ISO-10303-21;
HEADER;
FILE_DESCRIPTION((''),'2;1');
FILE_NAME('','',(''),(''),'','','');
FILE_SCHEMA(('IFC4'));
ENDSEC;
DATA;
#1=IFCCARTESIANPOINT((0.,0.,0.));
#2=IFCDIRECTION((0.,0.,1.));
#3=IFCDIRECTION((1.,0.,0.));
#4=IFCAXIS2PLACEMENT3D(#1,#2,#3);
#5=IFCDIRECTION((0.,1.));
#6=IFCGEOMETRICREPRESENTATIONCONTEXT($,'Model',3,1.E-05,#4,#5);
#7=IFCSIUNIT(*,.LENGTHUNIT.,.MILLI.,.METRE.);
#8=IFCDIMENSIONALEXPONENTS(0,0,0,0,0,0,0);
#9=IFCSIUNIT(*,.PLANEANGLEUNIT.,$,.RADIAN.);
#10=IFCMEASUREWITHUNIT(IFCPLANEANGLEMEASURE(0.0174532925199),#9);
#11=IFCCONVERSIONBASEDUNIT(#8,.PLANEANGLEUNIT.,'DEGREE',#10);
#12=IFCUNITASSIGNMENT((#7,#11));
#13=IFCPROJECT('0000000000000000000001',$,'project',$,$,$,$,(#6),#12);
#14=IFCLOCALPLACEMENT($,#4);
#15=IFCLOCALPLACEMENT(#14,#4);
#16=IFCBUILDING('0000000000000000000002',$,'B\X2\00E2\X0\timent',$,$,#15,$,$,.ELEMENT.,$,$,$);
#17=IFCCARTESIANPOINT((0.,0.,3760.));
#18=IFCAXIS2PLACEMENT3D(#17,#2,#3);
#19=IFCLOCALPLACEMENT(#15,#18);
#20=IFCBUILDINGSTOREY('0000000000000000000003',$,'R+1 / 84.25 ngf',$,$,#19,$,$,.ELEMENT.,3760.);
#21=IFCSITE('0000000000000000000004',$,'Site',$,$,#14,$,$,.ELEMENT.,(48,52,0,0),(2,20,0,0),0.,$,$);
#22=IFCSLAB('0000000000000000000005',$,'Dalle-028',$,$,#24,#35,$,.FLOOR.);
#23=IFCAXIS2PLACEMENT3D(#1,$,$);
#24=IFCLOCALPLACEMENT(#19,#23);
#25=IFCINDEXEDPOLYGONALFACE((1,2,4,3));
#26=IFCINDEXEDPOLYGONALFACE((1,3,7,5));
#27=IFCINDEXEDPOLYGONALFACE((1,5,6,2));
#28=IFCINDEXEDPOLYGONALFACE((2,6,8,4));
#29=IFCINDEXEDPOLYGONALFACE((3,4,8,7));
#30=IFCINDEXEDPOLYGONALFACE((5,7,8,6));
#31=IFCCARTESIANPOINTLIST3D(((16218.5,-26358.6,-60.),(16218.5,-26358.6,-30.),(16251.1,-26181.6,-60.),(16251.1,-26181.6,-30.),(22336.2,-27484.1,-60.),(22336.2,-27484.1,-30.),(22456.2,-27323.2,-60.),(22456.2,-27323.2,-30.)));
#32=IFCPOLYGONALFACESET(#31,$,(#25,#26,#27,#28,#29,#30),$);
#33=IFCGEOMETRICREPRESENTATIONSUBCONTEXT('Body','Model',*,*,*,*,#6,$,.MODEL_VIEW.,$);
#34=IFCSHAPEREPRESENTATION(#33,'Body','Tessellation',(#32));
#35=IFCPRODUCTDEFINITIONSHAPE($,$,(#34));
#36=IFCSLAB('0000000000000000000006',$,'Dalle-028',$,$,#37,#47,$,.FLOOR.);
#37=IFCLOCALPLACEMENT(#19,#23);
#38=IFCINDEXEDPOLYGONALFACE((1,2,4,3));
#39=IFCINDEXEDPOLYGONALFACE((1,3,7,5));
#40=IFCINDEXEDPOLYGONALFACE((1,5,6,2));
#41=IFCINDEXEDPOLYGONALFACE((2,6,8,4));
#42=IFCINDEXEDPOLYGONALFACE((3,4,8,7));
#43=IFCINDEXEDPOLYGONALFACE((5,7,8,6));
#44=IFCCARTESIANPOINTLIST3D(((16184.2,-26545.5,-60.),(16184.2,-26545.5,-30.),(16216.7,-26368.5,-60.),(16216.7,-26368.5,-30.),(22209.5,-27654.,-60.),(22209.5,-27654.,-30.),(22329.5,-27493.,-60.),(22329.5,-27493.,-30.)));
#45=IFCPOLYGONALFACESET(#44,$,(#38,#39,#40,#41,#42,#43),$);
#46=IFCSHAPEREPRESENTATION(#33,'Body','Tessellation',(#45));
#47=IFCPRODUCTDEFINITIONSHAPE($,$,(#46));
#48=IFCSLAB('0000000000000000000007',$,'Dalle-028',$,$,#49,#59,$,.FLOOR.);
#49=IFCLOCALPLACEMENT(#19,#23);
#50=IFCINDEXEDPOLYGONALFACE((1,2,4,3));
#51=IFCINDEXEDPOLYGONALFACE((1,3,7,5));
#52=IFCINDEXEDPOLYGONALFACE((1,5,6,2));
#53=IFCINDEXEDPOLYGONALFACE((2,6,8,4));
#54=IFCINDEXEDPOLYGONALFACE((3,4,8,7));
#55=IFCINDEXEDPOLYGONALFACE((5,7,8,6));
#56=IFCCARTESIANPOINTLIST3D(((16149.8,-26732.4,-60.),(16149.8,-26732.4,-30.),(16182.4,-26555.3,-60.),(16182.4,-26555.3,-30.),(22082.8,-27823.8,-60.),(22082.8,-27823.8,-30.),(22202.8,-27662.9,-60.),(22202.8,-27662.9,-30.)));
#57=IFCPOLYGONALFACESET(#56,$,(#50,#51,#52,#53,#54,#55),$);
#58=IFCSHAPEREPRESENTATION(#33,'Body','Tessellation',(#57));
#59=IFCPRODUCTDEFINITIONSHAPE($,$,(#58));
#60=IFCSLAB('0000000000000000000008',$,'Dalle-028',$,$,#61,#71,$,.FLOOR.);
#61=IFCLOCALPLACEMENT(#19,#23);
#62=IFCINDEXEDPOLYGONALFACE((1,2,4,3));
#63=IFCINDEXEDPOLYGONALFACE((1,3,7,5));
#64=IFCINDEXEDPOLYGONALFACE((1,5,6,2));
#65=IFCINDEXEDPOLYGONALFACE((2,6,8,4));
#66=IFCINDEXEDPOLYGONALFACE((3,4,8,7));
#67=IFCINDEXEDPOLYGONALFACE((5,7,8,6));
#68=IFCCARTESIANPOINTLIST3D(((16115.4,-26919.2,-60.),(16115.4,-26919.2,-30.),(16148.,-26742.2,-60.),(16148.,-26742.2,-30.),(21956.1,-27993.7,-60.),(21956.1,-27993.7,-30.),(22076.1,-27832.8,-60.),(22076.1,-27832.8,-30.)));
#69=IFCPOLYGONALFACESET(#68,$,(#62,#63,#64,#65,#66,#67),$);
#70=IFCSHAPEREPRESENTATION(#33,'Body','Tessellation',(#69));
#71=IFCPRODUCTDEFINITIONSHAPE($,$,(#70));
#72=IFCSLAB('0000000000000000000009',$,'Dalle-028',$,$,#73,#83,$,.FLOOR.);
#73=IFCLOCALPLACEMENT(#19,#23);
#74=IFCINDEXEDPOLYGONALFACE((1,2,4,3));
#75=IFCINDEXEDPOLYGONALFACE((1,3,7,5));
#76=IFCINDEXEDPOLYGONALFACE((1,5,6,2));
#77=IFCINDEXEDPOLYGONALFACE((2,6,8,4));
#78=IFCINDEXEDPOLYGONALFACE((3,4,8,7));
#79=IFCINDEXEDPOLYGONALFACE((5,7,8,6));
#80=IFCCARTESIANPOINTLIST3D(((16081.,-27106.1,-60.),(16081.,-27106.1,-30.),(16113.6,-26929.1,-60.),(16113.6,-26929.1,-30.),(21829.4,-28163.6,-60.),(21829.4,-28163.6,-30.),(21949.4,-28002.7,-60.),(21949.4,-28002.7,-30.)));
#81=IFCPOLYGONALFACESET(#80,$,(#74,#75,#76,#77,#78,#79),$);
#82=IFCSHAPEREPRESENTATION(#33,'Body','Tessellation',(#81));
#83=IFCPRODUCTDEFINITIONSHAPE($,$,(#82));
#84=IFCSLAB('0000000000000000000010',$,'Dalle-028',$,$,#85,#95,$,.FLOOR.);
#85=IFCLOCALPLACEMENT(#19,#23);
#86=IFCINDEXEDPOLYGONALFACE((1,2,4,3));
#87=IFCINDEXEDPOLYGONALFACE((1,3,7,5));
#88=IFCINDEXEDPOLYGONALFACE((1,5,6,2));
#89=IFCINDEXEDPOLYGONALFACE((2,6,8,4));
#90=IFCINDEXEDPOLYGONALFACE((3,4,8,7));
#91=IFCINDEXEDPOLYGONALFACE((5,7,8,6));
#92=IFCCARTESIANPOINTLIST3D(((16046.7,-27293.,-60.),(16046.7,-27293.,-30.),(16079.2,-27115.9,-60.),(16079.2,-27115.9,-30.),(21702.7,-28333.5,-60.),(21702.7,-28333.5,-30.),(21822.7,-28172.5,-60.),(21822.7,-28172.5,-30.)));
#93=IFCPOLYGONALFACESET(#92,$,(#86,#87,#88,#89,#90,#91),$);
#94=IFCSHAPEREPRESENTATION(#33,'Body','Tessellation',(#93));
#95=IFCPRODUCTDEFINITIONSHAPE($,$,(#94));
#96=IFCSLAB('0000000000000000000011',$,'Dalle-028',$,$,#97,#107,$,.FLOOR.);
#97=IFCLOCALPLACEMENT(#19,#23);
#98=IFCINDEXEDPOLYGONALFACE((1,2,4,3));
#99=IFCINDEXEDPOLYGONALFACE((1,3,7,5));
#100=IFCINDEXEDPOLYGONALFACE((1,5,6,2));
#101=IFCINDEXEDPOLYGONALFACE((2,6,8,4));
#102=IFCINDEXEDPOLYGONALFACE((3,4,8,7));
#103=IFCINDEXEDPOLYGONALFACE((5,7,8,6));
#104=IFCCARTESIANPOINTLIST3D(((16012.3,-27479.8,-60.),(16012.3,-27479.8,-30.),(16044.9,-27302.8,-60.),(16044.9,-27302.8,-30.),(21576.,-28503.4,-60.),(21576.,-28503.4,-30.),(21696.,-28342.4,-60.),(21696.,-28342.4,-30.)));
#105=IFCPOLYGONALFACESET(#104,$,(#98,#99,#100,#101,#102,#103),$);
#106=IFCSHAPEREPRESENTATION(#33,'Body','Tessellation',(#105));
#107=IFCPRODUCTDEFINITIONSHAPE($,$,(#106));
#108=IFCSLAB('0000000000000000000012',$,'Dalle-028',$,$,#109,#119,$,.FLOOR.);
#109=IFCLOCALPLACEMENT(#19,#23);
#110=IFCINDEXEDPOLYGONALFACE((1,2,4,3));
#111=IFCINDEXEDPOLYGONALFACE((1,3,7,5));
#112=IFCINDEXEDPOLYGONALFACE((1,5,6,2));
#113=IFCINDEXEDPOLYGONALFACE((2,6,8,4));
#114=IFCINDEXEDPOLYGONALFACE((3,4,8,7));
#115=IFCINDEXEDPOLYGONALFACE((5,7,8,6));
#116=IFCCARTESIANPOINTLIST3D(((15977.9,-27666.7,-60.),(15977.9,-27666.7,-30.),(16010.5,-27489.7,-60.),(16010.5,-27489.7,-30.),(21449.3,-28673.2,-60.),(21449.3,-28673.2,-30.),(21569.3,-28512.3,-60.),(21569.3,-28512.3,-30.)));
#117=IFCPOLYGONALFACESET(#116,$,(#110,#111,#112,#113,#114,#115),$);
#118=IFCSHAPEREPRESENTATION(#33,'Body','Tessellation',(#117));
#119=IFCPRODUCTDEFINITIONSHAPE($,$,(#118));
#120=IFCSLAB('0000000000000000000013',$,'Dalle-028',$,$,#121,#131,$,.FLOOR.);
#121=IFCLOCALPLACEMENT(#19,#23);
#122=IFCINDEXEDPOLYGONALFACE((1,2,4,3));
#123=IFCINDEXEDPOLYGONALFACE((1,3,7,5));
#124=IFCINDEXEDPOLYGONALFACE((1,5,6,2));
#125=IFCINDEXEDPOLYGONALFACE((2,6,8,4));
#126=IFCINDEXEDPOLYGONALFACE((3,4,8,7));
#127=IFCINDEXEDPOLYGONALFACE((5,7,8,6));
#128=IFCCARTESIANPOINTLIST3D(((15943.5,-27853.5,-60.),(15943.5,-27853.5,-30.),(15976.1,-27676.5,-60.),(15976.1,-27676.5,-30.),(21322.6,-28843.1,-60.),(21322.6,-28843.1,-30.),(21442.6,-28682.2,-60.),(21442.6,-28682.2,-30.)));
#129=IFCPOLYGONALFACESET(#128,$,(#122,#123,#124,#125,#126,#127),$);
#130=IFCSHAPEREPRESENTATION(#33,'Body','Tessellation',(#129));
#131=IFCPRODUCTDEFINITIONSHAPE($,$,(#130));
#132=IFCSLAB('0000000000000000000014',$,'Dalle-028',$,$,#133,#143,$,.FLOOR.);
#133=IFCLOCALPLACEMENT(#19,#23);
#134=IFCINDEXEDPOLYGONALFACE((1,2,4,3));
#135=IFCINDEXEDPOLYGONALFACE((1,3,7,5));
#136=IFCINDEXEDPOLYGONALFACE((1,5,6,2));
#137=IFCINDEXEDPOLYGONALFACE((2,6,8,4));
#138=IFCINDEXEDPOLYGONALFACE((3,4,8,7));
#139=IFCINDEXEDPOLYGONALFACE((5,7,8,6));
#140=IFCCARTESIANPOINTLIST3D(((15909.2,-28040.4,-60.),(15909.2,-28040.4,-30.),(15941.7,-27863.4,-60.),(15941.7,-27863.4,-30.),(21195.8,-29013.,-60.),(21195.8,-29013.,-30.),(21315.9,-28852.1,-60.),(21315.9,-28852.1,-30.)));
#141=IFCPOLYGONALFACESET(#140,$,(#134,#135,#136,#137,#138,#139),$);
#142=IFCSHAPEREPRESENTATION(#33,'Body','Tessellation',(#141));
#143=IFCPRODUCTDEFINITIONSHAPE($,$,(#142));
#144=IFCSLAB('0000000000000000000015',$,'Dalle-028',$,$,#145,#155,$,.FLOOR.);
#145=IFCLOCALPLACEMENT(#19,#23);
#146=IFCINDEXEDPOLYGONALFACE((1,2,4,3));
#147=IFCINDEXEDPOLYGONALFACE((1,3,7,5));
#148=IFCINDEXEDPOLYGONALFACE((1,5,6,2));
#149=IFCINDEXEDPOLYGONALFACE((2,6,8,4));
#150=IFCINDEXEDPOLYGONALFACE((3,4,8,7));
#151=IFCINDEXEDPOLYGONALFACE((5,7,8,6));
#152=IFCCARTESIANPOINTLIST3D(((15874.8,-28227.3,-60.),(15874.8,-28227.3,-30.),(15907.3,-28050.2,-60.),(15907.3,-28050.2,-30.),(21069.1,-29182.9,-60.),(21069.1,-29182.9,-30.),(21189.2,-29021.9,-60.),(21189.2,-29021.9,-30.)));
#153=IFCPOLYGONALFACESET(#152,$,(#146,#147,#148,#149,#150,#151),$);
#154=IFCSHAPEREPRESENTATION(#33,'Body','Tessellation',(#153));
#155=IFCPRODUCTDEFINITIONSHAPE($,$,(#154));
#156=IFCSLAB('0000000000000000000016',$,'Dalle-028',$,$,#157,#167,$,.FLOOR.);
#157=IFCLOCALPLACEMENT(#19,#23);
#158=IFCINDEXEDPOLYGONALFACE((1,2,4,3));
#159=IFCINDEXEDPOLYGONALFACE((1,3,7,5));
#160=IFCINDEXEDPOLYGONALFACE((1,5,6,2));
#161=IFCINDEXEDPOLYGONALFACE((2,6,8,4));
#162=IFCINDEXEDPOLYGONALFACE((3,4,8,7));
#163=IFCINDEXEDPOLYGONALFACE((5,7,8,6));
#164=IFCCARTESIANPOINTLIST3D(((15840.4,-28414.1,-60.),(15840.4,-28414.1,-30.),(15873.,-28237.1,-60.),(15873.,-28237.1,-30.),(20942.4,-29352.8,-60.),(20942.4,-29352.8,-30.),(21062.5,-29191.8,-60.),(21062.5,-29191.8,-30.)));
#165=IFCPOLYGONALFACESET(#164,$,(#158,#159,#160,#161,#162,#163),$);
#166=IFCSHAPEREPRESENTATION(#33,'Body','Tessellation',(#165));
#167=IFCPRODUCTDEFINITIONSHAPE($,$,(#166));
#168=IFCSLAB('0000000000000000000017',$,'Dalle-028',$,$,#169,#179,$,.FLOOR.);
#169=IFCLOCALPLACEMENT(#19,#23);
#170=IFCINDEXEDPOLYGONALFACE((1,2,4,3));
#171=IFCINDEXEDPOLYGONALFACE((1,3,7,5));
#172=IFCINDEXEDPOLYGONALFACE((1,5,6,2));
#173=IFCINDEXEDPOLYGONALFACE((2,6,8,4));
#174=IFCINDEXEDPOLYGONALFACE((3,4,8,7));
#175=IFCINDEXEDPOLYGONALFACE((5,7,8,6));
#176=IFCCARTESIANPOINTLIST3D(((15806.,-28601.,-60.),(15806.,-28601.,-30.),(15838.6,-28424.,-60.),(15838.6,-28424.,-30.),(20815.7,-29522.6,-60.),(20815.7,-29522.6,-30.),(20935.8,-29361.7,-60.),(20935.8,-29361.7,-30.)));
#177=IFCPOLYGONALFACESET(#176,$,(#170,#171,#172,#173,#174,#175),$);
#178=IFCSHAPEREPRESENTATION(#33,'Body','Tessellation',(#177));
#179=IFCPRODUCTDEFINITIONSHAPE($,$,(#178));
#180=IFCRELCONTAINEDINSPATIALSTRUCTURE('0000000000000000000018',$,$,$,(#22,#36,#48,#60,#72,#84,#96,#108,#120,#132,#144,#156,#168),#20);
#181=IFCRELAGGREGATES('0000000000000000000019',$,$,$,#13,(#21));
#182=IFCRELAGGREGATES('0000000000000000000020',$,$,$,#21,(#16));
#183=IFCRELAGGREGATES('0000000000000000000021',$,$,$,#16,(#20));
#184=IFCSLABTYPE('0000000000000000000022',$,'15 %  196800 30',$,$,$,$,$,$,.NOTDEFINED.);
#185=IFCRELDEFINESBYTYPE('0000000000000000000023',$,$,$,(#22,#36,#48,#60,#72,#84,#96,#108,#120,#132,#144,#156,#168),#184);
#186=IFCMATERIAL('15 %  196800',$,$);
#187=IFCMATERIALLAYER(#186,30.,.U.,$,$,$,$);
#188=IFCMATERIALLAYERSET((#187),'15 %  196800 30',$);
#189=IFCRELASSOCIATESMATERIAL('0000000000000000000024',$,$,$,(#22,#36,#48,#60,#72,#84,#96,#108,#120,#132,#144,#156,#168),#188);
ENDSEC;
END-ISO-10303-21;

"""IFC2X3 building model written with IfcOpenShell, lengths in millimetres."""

from ifc_helpers import new_model, entity, si_unit, converted_unit, direction, frame, origin_with_axes, place, context, subcontext, project, spatial, polyline, outline, extrude, material, layer, layer_set, layer_usage, type_object, element, save


model = new_model("IFC2X3")

# Units and contexts
model_context = context("Model", 3, precision=1e-05, world=origin_with_axes(), true_north=direction((0.0, 1.0)))
body_context = subcontext(model_context, "Body", "Model", "MODEL_VIEW")
ifc_project = project(units=[si_unit("LENGTHUNIT", "METRE", prefix="MILLI"), converted_unit("PLANEANGLEUNIT", "DEGREE", entity("IfcPlaneAngleMeasure", 0.0174532925199), si_unit("PLANEANGLEUNIT", "RADIAN"), dimensions=[0, 0, 0, 0, 0, 0, 0])], contexts=[model_context])

# Site, building, storey
site_placement = place(None, origin_with_axes())
site = spatial("IfcSite", under=ifc_project, at=site_placement, Name="Site", CompositionType="ELEMENT", RefLatitude=(48, 52, 0, 0), RefLongitude=(2, 20, 0, 0), RefElevation=0.0)
building_placement = place(site_placement, origin_with_axes())
building = spatial("IfcBuilding", under=site, at=building_placement, Name="Bâtiment", CompositionType="ELEMENT")
storey_placement = place(building_placement, frame((0.0, 0.0, 3760.0), z_axis=(0.0, 0.0, 1.0), x_axis=(1.0, 0.0, 0.0)))
storey = spatial("IfcBuildingStorey", under=building, at=storey_placement, Name="R+1 / 84.25 ngf", CompositionType="ELEMENT", Elevation=3760.0)

# Slabs
ifc_material_1 = material(Name="15 %  196800")
ifc_layer_1 = layer(ifc_material_1, 30.0, ventilated="UNKNOWN")
ifc_layer_set_1 = layer_set([ifc_layer_1], Name="15 %  196800 30")
slab_type = type_object("IfcSlabType", Name="15 %  196800 30", PredefinedType="NOTDEFINED")
ifc_layer_usage_1 = layer_usage(ifc_layer_set_1, "AXIS3", "NEGATIVE", 30.0)
slab_1_placement = place(storey_placement, frame((16251.1, -26181.6, -30.0), z_axis=(0.0, 0.0, 1.0), x_axis=(1.0, 0.0, 0.0)))
element("IfcSlab", 1, at=slab_1_placement, inside=storey, type_object=slab_type, material=ifc_layer_usage_1, Name="Dalle-028", PredefinedType="FLOOR", context=body_context, shape_type="SweptSolid", body=[
    extrude(outline(polyline([(0.0, 0.0), (-32.6, -177.0), (6085.1, -1302.5), (6205.1, -1141.6), (0.0, 0.0)])), frame((0.0, 0.0, -30.0), z_axis=(0.0, 0.0, 1.0), x_axis=(1.0, 0.0, 0.0)), (0.0, 0.0, 1.0), 30.0),
])
ifc_layer_usage_2 = layer_usage(ifc_layer_set_1, "AXIS3", "NEGATIVE", 30.0)
slab_2_placement = place(storey_placement, frame((16216.7, -26368.5, -30.0), z_axis=(0.0, 0.0, 1.0), x_axis=(1.0, 0.0, 0.0)))
element("IfcSlab", 2, at=slab_2_placement, inside=storey, type_object=slab_type, material=ifc_layer_usage_2, Name="Dalle-028", PredefinedType="FLOOR", context=body_context, shape_type="SweptSolid", body=[
    extrude(outline(polyline([(0.0, 0.0), (-32.6, -177.0), (5992.8, -1285.5), (6112.8, -1124.6), (0.0, 0.0)])), frame((0.0, 0.0, -30.0), z_axis=(0.0, 0.0, 1.0), x_axis=(1.0, 0.0, 0.0)), (0.0, 0.0, 1.0), 30.0),
])
ifc_layer_usage_3 = layer_usage(ifc_layer_set_1, "AXIS3", "NEGATIVE", 30.0)
slab_3_placement = place(storey_placement, frame((16182.4, -26555.3, -30.0), z_axis=(0.0, 0.0, 1.0), x_axis=(1.0, 0.0, 0.0)))
element("IfcSlab", 3, at=slab_3_placement, inside=storey, type_object=slab_type, material=ifc_layer_usage_3, Name="Dalle-028", PredefinedType="FLOOR", context=body_context, shape_type="SweptSolid", body=[
    extrude(outline(polyline([(0.0, 0.0), (-32.6, -177.0), (5900.4, -1268.5), (6020.5, -1107.6), (0.0, 0.0)])), frame((0.0, 0.0, -30.0), z_axis=(0.0, 0.0, 1.0), x_axis=(1.0, 0.0, 0.0)), (0.0, 0.0, 1.0), 30.0),
])
ifc_layer_usage_4 = layer_usage(ifc_layer_set_1, "AXIS3", "NEGATIVE", 30.0)
slab_4_placement = place(storey_placement, frame((16148.0, -26742.2, -30.0), z_axis=(0.0, 0.0, 1.0), x_axis=(1.0, 0.0, 0.0)))
element("IfcSlab", 4, at=slab_4_placement, inside=storey, type_object=slab_type, material=ifc_layer_usage_4, Name="Dalle-028", PredefinedType="FLOOR", context=body_context, shape_type="SweptSolid", body=[
    extrude(outline(polyline([(0.0, 0.0), (-32.6, -177.0), (5808.1, -1251.5), (5928.1, -1090.6), (0.0, 0.0)])), frame((0.0, 0.0, -30.0), z_axis=(0.0, 0.0, 1.0), x_axis=(1.0, 0.0, 0.0)), (0.0, 0.0, 1.0), 30.0),
])
ifc_layer_usage_5 = layer_usage(ifc_layer_set_1, "AXIS3", "NEGATIVE", 30.0)
slab_5_placement = place(storey_placement, frame((16113.6, -26929.1, -30.0), z_axis=(0.0, 0.0, 1.0), x_axis=(1.0, 0.0, 0.0)))
element("IfcSlab", 5, at=slab_5_placement, inside=storey, type_object=slab_type, material=ifc_layer_usage_5, Name="Dalle-028", PredefinedType="FLOOR", context=body_context, shape_type="SweptSolid", body=[
    extrude(outline(polyline([(0.0, 0.0), (-32.6, -177.0), (5715.8, -1234.5), (5835.8, -1073.6), (0.0, 0.0)])), frame((0.0, 0.0, -30.0), z_axis=(0.0, 0.0, 1.0), x_axis=(1.0, 0.0, 0.0)), (0.0, 0.0, 1.0), 30.0),
])
ifc_layer_usage_6 = layer_usage(ifc_layer_set_1, "AXIS3", "NEGATIVE", 30.0)
slab_6_placement = place(storey_placement, frame((16079.2, -27115.9, -30.0), z_axis=(0.0, 0.0, 1.0), x_axis=(1.0, 0.0, 0.0)))
element("IfcSlab", 6, at=slab_6_placement, inside=storey, type_object=slab_type, material=ifc_layer_usage_6, Name="Dalle-028", PredefinedType="FLOOR", context=body_context, shape_type="SweptSolid", body=[
    extrude(outline(polyline([(0.0, 0.0), (-32.6, -177.0), (5623.4, -1217.6), (5743.5, -1056.6), (0.0, 0.0)])), frame((0.0, 0.0, -30.0), z_axis=(0.0, 0.0, 1.0), x_axis=(1.0, 0.0, 0.0)), (0.0, 0.0, 1.0), 30.0),
])
ifc_layer_usage_7 = layer_usage(ifc_layer_set_1, "AXIS3", "NEGATIVE", 30.0)
slab_7_placement = place(storey_placement, frame((16044.9, -27302.8, -30.0), z_axis=(0.0, 0.0, 1.0), x_axis=(1.0, 0.0, 0.0)))
element("IfcSlab", 7, at=slab_7_placement, inside=storey, type_object=slab_type, material=ifc_layer_usage_7, Name="Dalle-028", PredefinedType="FLOOR", context=body_context, shape_type="SweptSolid", body=[
    extrude(outline(polyline([(0.0, 0.0), (-32.6, -177.0), (5531.1, -1200.6), (5651.2, -1039.6), (0.0, 0.0)])), frame((0.0, 0.0, -30.0), z_axis=(0.0, 0.0, 1.0), x_axis=(1.0, 0.0, 0.0)), (0.0, 0.0, 1.0), 30.0),
])
ifc_layer_usage_8 = layer_usage(ifc_layer_set_1, "AXIS3", "NEGATIVE", 30.0)
slab_8_placement = place(storey_placement, frame((16010.5, -27489.7, -30.0), z_axis=(0.0, 0.0, 1.0), x_axis=(1.0, 0.0, 0.0)))
element("IfcSlab", 8, at=slab_8_placement, inside=storey, type_object=slab_type, material=ifc_layer_usage_8, Name="Dalle-028", PredefinedType="FLOOR", context=body_context, shape_type="SweptSolid", body=[
    extrude(outline(polyline([(0.0, 0.0), (-32.6, -177.0), (5438.8, -1183.6), (5558.8, -1022.7), (0.0, 0.0)])), frame((0.0, 0.0, -30.0), z_axis=(0.0, 0.0, 1.0), x_axis=(1.0, 0.0, 0.0)), (0.0, 0.0, 1.0), 30.0),
])
ifc_layer_usage_9 = layer_usage(ifc_layer_set_1, "AXIS3", "NEGATIVE", 30.0)
slab_9_placement = place(storey_placement, frame((15976.1, -27676.5, -30.0), z_axis=(0.0, 0.0, 1.0), x_axis=(1.0, 0.0, 0.0)))
element("IfcSlab", 9, at=slab_9_placement, inside=storey, type_object=slab_type, material=ifc_layer_usage_9, Name="Dalle-028", PredefinedType="FLOOR", context=body_context, shape_type="SweptSolid", body=[
    extrude(outline(polyline([(0.0, 0.0), (-32.6, -177.0), (5346.5, -1166.6), (5466.5, -1005.7), (0.0, 0.0)])), frame((0.0, 0.0, -30.0), z_axis=(0.0, 0.0, 1.0), x_axis=(1.0, 0.0, 0.0)), (0.0, 0.0, 1.0), 30.0),
])
ifc_layer_usage_10 = layer_usage(ifc_layer_set_1, "AXIS3", "NEGATIVE", 30.0)
slab_10_placement = place(storey_placement, frame((15941.7, -27863.4, -30.0), z_axis=(0.0, 0.0, 1.0), x_axis=(1.0, 0.0, 0.0)))
element("IfcSlab", 10, at=slab_10_placement, inside=storey, type_object=slab_type, material=ifc_layer_usage_10, Name="Dalle-028", PredefinedType="FLOOR", context=body_context, shape_type="SweptSolid", body=[
    extrude(outline(polyline([(0.0, 0.0), (-32.6, -177.0), (5254.1, -1149.6), (5374.2, -988.7), (0.0, 0.0)])), frame((0.0, 0.0, -30.0), z_axis=(0.0, 0.0, 1.0), x_axis=(1.0, 0.0, 0.0)), (0.0, 0.0, 1.0), 30.0),
])
ifc_layer_usage_11 = layer_usage(ifc_layer_set_1, "AXIS3", "NEGATIVE", 30.0)
slab_11_placement = place(storey_placement, frame((15907.3, -28050.2, -30.0), z_axis=(0.0, 0.0, 1.0), x_axis=(1.0, 0.0, 0.0)))
element("IfcSlab", 11, at=slab_11_placement, inside=storey, type_object=slab_type, material=ifc_layer_usage_11, Name="Dalle-028", PredefinedType="FLOOR", context=body_context, shape_type="SweptSolid", body=[
    extrude(outline(polyline([(0.0, 0.0), (-32.6, -177.0), (5161.8, -1132.6), (5281.8, -971.7), (0.0, 0.0)])), frame((0.0, 0.0, -30.0), z_axis=(0.0, 0.0, 1.0), x_axis=(1.0, 0.0, 0.0)), (0.0, 0.0, 1.0), 30.0),
])
ifc_layer_usage_12 = layer_usage(ifc_layer_set_1, "AXIS3", "NEGATIVE", 30.0)
slab_12_placement = place(storey_placement, frame((15873.0, -28237.1, -30.0), z_axis=(0.0, 0.0, 1.0), x_axis=(1.0, 0.0, 0.0)))
element("IfcSlab", 12, at=slab_12_placement, inside=storey, type_object=slab_type, material=ifc_layer_usage_12, Name="Dalle-028", PredefinedType="FLOOR", context=body_context, shape_type="SweptSolid", body=[
    extrude(outline(polyline([(0.0, 0.0), (-32.6, -177.0), (5069.5, -1115.6), (5189.5, -954.7), (0.0, 0.0)])), frame((0.0, 0.0, -30.0), z_axis=(0.0, 0.0, 1.0), x_axis=(1.0, 0.0, 0.0)), (0.0, 0.0, 1.0), 30.0),
])
ifc_layer_usage_13 = layer_usage(ifc_layer_set_1, "AXIS3", "NEGATIVE", 30.0)
slab_13_placement = place(storey_placement, frame((15838.6, -28424.0, -30.0), z_axis=(0.0, 0.0, 1.0), x_axis=(1.0, 0.0, 0.0)))
element("IfcSlab", 13, at=slab_13_placement, inside=storey, type_object=slab_type, material=ifc_layer_usage_13, Name="Dalle-028", PredefinedType="FLOOR", context=body_context, shape_type="SweptSolid", body=[
    extrude(outline(polyline([(0.0, 0.0), (-32.6, -177.0), (4977.1, -1098.7), (5097.2, -937.7), (0.0, 0.0)])), frame((0.0, 0.0, -30.0), z_axis=(0.0, 0.0, 1.0), x_axis=(1.0, 0.0, 0.0)), (0.0, 0.0, 1.0), 30.0),
])

save(model, "model.ifc")
